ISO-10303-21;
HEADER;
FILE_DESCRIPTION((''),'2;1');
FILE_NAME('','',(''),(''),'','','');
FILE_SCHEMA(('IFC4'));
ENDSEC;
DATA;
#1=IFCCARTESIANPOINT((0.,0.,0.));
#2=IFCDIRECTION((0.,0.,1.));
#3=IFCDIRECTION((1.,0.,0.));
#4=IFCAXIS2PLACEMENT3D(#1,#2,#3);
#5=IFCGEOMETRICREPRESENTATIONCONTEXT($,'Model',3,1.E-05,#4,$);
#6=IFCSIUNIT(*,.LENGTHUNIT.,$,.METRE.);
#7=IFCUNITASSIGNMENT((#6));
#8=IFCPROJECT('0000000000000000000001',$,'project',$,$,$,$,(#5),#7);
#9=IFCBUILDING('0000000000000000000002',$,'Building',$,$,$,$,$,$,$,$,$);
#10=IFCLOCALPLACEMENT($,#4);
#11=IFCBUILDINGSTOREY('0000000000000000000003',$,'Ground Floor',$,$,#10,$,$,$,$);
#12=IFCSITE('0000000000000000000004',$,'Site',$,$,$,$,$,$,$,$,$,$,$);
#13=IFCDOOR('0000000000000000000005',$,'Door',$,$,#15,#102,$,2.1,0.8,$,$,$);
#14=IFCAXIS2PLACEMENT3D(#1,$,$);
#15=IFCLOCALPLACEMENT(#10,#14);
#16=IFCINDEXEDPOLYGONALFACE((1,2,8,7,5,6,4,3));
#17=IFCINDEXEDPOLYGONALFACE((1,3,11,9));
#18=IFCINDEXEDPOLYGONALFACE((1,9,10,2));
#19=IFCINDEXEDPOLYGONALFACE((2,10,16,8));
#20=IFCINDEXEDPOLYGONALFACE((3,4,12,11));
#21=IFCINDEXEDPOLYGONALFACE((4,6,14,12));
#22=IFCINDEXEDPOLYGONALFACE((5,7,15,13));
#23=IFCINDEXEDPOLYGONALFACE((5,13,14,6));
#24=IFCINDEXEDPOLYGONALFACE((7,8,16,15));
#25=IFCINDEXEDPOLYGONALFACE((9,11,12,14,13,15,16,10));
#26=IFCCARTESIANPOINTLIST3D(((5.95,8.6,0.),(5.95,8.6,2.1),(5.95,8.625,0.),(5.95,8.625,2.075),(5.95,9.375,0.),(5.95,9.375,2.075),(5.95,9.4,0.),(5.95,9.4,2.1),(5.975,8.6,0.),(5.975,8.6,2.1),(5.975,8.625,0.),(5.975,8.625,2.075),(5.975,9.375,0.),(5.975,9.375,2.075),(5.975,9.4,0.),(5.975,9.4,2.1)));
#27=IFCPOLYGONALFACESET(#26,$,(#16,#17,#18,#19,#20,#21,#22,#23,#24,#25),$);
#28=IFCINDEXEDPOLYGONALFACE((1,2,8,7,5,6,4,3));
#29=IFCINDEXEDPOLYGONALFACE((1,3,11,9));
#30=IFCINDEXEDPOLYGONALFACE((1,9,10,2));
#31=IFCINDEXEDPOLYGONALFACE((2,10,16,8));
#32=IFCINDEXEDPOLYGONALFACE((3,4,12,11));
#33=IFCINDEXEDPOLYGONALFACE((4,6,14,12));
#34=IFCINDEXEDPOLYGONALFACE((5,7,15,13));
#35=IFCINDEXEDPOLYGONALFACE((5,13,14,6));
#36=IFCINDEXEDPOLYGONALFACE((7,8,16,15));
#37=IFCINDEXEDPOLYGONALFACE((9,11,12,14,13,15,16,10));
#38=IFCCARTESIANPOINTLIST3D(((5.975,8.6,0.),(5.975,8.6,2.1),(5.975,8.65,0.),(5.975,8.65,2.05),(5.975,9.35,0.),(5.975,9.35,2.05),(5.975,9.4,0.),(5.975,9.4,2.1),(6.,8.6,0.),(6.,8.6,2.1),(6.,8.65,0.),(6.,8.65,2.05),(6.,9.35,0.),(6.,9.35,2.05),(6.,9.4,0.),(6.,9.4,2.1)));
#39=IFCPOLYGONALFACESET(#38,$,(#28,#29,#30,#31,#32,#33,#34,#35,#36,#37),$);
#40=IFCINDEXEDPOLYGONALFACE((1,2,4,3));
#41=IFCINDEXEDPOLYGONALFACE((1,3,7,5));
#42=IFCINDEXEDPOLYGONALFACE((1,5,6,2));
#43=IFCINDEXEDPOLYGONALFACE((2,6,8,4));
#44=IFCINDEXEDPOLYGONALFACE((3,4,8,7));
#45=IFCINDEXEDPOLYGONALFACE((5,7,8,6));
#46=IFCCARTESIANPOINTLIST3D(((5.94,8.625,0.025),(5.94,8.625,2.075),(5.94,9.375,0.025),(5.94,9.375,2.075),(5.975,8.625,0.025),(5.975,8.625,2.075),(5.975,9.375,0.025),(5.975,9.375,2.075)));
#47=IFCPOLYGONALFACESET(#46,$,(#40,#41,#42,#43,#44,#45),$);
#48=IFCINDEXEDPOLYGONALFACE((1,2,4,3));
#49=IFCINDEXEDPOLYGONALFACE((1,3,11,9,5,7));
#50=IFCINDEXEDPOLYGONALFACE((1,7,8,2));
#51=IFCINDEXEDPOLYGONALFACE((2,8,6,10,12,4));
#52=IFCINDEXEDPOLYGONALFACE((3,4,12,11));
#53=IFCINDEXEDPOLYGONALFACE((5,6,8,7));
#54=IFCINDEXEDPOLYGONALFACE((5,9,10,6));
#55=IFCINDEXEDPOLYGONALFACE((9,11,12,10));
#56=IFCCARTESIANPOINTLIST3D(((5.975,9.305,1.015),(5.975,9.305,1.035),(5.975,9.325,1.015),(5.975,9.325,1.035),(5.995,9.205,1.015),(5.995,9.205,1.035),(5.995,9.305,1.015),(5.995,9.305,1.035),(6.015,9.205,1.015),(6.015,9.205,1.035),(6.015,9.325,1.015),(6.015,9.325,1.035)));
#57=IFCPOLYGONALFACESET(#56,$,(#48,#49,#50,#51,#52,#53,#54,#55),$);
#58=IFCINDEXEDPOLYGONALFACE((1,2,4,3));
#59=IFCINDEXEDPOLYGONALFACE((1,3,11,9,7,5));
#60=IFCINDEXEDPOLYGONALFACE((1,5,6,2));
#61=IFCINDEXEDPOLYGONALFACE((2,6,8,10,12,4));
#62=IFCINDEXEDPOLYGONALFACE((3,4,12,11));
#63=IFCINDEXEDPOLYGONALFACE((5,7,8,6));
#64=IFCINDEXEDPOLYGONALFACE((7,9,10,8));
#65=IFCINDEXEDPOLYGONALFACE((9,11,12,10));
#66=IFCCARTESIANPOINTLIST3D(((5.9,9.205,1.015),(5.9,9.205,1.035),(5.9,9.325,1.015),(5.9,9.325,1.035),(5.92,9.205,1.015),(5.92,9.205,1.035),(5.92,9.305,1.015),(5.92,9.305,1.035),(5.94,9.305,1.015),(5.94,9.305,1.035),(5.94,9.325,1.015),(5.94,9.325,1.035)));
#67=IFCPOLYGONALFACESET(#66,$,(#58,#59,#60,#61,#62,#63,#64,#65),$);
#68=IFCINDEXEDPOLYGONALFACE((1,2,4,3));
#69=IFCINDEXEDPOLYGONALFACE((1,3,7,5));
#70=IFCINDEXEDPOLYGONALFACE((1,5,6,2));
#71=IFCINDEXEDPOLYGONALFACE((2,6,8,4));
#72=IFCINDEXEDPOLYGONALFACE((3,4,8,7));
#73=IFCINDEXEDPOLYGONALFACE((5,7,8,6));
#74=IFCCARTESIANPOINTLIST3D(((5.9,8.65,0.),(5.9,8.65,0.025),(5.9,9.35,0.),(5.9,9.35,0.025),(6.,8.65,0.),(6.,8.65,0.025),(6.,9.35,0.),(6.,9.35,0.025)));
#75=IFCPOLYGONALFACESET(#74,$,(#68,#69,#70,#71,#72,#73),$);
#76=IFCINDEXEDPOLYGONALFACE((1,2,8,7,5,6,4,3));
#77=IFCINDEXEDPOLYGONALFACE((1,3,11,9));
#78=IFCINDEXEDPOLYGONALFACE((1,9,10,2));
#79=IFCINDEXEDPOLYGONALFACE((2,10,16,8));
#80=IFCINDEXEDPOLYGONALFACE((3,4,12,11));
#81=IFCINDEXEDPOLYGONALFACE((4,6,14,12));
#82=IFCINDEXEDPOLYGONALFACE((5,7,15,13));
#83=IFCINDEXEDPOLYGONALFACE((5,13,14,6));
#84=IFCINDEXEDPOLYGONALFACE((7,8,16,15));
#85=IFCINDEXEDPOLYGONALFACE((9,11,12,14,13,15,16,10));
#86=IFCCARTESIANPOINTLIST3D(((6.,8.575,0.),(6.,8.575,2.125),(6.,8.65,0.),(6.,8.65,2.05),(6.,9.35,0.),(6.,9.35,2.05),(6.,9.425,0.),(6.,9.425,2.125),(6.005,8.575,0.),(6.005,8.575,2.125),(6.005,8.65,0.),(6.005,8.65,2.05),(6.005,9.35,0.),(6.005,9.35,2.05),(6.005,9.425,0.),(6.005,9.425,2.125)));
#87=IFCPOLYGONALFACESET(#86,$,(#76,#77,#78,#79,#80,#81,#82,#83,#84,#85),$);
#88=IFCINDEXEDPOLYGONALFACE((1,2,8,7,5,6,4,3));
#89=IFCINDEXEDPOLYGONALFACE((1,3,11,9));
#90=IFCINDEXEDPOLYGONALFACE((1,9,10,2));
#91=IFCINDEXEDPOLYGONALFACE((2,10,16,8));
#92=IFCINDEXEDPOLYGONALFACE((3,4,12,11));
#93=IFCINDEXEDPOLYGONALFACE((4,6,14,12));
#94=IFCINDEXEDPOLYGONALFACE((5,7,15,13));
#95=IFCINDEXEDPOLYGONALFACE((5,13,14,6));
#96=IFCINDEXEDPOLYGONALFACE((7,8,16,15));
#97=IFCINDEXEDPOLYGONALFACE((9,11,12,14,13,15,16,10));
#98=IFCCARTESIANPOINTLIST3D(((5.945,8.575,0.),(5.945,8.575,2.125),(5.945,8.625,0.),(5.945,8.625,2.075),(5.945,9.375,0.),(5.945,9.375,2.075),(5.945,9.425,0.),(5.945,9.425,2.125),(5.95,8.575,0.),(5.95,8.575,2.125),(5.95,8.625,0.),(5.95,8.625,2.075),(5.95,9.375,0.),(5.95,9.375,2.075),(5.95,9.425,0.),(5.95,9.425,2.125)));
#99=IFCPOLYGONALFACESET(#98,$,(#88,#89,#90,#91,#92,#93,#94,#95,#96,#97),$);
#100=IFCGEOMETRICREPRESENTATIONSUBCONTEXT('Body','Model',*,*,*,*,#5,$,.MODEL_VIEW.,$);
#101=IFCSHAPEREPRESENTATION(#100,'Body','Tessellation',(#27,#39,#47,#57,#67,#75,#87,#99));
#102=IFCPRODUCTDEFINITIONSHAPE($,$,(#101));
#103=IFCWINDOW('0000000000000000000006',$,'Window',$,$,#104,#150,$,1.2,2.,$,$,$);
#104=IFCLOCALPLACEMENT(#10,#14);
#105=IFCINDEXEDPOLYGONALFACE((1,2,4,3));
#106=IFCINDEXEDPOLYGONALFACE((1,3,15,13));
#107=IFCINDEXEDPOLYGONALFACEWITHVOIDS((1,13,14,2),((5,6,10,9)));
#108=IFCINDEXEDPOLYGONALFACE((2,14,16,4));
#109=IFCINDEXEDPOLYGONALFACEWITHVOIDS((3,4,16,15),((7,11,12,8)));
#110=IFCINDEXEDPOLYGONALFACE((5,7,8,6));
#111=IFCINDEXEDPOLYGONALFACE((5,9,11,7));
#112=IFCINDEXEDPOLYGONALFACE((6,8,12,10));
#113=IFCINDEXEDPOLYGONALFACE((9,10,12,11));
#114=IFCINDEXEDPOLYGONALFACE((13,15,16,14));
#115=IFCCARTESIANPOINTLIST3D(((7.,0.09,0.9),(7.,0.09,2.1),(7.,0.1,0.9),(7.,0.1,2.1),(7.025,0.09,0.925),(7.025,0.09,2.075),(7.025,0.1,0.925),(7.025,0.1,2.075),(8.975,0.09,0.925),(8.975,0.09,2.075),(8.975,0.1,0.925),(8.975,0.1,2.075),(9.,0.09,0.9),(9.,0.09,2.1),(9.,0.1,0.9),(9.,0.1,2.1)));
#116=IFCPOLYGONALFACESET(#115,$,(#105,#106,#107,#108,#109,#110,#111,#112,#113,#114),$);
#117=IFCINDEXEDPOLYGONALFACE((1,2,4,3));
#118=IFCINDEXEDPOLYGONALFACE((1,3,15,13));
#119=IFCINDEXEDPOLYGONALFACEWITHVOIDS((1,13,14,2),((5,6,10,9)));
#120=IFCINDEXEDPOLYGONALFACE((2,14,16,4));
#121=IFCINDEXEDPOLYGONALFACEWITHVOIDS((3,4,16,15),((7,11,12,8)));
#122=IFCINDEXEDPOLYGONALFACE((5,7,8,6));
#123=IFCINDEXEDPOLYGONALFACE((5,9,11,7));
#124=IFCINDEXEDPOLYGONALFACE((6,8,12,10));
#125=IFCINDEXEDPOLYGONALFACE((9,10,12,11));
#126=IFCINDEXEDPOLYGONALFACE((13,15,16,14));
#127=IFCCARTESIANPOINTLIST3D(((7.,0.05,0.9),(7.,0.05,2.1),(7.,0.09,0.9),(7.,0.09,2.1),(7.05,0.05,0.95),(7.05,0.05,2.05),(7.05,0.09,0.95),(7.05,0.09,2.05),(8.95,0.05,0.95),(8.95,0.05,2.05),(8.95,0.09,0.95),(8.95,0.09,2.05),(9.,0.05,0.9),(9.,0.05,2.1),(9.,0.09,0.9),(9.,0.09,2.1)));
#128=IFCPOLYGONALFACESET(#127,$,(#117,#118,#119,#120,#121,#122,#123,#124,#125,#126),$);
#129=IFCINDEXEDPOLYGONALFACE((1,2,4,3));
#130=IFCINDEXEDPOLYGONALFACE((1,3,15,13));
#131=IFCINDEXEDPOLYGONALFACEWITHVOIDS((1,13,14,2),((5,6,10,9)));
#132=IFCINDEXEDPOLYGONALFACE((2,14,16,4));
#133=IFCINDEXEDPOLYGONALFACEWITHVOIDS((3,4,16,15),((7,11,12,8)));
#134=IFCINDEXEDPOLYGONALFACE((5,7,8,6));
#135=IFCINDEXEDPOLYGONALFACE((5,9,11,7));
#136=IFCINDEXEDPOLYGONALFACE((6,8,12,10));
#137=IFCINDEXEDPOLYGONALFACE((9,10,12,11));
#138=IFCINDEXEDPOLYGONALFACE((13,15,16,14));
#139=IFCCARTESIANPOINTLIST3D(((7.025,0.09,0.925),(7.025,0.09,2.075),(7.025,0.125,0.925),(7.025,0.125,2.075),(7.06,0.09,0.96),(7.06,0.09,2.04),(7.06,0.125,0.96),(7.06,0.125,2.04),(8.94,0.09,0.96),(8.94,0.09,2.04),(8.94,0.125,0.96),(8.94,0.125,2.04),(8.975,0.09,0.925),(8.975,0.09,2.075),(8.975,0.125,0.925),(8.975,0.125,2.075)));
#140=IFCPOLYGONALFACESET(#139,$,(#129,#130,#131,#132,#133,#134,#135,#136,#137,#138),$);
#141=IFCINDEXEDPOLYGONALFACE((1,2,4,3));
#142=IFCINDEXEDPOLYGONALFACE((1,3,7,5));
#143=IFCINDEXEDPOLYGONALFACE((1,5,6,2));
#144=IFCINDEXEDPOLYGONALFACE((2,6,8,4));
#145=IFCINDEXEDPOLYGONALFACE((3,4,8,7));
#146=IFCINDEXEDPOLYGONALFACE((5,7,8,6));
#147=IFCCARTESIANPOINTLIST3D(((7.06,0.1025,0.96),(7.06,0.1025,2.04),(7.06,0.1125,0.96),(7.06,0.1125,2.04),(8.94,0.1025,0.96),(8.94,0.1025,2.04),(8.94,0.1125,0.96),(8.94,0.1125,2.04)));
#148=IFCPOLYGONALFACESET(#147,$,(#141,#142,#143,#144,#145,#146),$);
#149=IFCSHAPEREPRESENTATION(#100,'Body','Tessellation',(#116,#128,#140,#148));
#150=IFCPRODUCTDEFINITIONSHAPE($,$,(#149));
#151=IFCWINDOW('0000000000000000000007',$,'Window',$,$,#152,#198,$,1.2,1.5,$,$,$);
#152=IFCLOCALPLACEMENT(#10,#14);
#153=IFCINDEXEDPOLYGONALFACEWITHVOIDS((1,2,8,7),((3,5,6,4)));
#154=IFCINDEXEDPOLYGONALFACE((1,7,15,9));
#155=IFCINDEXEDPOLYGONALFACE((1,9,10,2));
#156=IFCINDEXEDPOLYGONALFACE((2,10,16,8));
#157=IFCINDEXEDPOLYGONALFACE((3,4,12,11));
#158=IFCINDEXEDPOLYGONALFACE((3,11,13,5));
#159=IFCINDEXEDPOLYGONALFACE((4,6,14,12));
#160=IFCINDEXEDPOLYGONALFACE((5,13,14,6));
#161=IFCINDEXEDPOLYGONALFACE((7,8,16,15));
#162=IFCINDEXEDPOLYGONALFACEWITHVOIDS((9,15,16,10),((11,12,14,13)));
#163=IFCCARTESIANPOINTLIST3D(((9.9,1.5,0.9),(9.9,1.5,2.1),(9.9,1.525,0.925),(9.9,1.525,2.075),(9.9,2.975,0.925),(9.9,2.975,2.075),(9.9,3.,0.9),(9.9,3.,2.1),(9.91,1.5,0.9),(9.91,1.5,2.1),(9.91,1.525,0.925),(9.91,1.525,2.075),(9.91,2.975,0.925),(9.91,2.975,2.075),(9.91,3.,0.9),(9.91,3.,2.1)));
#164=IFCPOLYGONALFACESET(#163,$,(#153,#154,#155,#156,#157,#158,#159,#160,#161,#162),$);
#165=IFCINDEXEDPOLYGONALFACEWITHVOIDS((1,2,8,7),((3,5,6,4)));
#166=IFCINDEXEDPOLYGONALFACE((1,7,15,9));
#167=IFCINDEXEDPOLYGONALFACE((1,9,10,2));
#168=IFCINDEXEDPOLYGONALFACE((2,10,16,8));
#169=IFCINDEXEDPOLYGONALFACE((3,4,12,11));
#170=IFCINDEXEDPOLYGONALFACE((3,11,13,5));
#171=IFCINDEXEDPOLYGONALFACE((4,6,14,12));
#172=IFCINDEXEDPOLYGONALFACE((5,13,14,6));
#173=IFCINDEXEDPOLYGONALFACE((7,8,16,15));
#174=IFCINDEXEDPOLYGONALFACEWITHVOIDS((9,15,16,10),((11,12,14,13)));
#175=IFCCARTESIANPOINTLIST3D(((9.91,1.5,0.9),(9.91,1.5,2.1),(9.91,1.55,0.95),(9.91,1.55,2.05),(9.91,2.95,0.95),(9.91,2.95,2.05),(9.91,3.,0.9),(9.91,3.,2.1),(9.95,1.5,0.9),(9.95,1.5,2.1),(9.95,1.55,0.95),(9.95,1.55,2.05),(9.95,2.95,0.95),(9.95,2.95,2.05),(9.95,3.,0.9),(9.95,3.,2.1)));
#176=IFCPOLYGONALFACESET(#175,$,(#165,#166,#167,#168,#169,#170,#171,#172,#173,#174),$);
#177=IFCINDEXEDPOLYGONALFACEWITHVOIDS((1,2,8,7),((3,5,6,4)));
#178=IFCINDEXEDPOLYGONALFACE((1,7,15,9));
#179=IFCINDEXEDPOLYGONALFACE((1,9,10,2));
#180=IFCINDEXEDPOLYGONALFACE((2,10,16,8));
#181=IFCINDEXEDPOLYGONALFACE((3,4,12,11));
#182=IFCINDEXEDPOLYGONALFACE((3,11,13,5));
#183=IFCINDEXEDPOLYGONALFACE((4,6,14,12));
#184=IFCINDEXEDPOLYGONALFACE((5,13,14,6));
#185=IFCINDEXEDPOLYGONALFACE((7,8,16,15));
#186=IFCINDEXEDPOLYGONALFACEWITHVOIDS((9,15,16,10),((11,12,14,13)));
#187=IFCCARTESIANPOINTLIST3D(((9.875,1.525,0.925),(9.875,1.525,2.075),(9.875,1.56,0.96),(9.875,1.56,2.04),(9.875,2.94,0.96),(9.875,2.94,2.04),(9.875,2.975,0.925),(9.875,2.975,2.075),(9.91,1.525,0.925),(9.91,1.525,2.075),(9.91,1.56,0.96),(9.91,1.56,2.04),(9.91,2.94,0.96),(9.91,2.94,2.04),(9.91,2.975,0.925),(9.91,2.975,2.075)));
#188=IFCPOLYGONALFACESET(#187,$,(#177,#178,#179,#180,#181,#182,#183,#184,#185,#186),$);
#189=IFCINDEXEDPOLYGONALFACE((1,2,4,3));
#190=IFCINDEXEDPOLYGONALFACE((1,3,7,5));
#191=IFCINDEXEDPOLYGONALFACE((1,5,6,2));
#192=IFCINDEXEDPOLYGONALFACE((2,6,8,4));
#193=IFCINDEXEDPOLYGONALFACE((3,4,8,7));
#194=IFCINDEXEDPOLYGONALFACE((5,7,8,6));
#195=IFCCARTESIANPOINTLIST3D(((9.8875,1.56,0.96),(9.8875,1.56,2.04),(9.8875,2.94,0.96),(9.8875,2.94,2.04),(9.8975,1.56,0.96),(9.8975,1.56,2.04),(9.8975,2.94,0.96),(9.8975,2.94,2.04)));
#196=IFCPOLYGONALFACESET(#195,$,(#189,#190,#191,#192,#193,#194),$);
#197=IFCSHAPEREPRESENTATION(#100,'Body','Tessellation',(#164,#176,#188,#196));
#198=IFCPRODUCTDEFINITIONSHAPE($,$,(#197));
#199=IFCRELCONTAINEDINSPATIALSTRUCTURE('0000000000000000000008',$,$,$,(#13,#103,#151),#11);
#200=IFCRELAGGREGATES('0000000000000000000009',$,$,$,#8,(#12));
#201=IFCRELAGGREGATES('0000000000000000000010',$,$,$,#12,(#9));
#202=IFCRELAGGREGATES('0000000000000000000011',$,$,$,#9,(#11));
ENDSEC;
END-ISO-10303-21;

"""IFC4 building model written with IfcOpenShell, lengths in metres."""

from ifc_helpers import new_model, si_unit, frame, origin_with_axes, place, context, subcontext, project, spatial, line, indexed_curve, outline, extrude, element, save


model = new_model("IFC4")

# Units and contexts
model_context = context("Model", 3, precision=1e-05, world=origin_with_axes())
body_context = subcontext(model_context, "Body", "Model", "MODEL_VIEW")
ifc_project = project(units=[si_unit("LENGTHUNIT", "METRE")], contexts=[model_context])

# Site, building, storey
site = spatial("IfcSite", under=ifc_project, Name="Site")
building = spatial("IfcBuilding", under=site, Name="Building")
storey_placement = place(None, origin_with_axes())
storey = spatial("IfcBuildingStorey", under=building, at=storey_placement, Name="Ground Floor")

# Door
door_1_placement = place(storey_placement, frame((6.0, 8.6, 0.0), z_axis=(0.0, 0.0, 1.0), x_axis=(0.0, 1.0, 0.0)))
element("IfcDoor", 1, at=door_1_placement, inside=storey, Name="Door", OverallHeight=2.1, OverallWidth=0.8, context=body_context, shape_type="SweptSolid", body=[
    extrude(outline(indexed_curve([(0.0, 0.0), (0.0, 2.1), (0.8, 2.1), (0.8, 0.0), (0.775, 0.0), (0.775, 2.075), (0.025, 2.075), (0.025, 0.0)], segments=[line(1, 2, 3, 4, 5, 6, 7, 8, 1)])), frame((0.0, 0.025, 0.0), z_axis=(0.0, -1.0, 0.0), x_axis=(1.0, 0.0, 0.0)), (0.0, 0.0, -1.0), 0.025),
    extrude(outline(indexed_curve([(0.0, 0.0), (0.0, 2.1), (0.8, 2.1), (0.8, 0.0), (0.75, 0.0), (0.75, 2.05), (0.05, 2.05), (0.05, 0.0)], segments=[line(1, 2, 3, 4, 5, 6, 7, 8, 1)])), frame((0.0, 0.0, 0.0), z_axis=(0.0, -1.0, 0.0), x_axis=(1.0, 0.0, 0.0)), (0.0, 0.0, -1.0), 0.025),
    extrude(outline(indexed_curve([(0.0, 0.0), (0.75, 0.0), (0.75, 0.035), (0.0, 0.035)], segments=[line(1, 2, 3, 4, 1)])), frame((0.025, 0.025, 0.025), z_axis=(0.0, 0.0, 1.0), x_axis=(1.0, 0.0, 0.0)), (0.0, 0.0, 1.0), 2.05),
    extrude(outline(indexed_curve([(0.0, 0.0), (0.0, -0.04), (-0.12, -0.04), (-0.12, -0.02), (-0.02, -0.02), (-0.02, 0.0)], segments=[line(1, 2, 3, 4, 5, 6, 1)])), frame((0.725, 0.025, 1.015), z_axis=(0.0, 0.0, 1.0), x_axis=(1.0, 0.0, 0.0)), (0.0, 0.0, 1.0), 0.02),
    extrude(outline(indexed_curve([(0.0, 0.0), (0.0, 0.04), (-0.12, 0.04), (-0.12, 0.02), (-0.02, 0.02), (-0.02, 0.0)], segments=[line(1, 2, 3, 4, 5, 6, 1)])), frame((0.725, 0.06, 1.015), z_axis=(0.0, 0.0, 1.0), x_axis=(1.0, 0.0, 0.0)), (0.0, 0.0, 1.0), 0.02),
    extrude(outline(indexed_curve([(0.0, 0.0), (0.7, 0.0), (0.7, 0.1), (0.0, 0.1)], segments=[line(1, 2, 3, 4, 1)])), frame((0.05, 0.0, 0.0), z_axis=(0.0, 0.0, 1.0), x_axis=(1.0, 0.0, 0.0)), (0.0, 0.0, 1.0), 0.025),
    extrude(outline(indexed_curve([(0.0, 0.0), (0.0, 2.125), (0.85, 2.125), (0.85, 0.0), (0.775, 0.0), (0.775, 2.05), (0.075, 2.05), (0.075, 0.0)], segments=[line(1, 2, 3, 4, 5, 6, 7, 8, 1)])), frame((-0.025, -0.005, 0.0), z_axis=(0.0, -1.0, 0.0), x_axis=(1.0, 0.0, 0.0)), (0.0, 0.0, -1.0), 0.005),
    extrude(outline(indexed_curve([(0.0, 0.0), (0.0, 2.125), (0.85, 2.125), (0.85, 0.0), (0.8, 0.0), (0.8, 2.075), (0.05, 2.075), (0.05, 0.0)], segments=[line(1, 2, 3, 4, 5, 6, 7, 8, 1)])), frame((-0.025, 0.05, 0.0), z_axis=(0.0, -1.0, 0.0), x_axis=(1.0, 0.0, 0.0)), (0.0, 0.0, -1.0), 0.005),
])

# Windows
window_1_placement = place(storey_placement, frame((7.0, 0.0, 0.9), z_axis=(0.0, 0.0, 1.0), x_axis=(1.0, 0.0, 0.0)))
element("IfcWindow", 2, at=window_1_placement, inside=storey, Name="Window", OverallHeight=1.2, OverallWidth=2.0, context=body_context, shape_type="SweptSolid", body=[
    extrude(outline(indexed_curve([(0.0, 0.0), (2.0, 0.0), (2.0, 1.2), (0.0, 1.2)], segments=[line(1, 2, 3, 4, 1)]), holes=[indexed_curve([(0.025, 0.025), (1.975, 0.025), (1.975, 1.175), (0.025, 1.175)], segments=[line(1, 2, 3, 4, 1)])]), frame((0.0, 0.09, 0.0), z_axis=(0.0, -1.0, 0.0), x_axis=(1.0, 0.0, 0.0)), (0.0, 0.0, -1.0), 0.01),
    extrude(outline(indexed_curve([(0.0, 0.0), (2.0, 0.0), (2.0, 1.2), (0.0, 1.2)], segments=[line(1, 2, 3, 4, 1)]), holes=[indexed_curve([(0.05, 0.05), (1.95, 0.05), (1.95, 1.15), (0.05, 1.15)], segments=[line(1, 2, 3, 4, 1)])]), frame((0.0, 0.05, 0.0), z_axis=(0.0, -1.0, 0.0), x_axis=(1.0, 0.0, 0.0)), (0.0, 0.0, -1.0), 0.04),
    extrude(outline(indexed_curve([(0.0, 0.0), (1.95, 0.0), (1.95, 1.15), (0.0, 1.15)], segments=[line(1, 2, 3, 4, 1)]), holes=[indexed_curve([(0.035, 0.035), (1.915, 0.035), (1.915, 1.115), (0.035, 1.115)], segments=[line(1, 2, 3, 4, 1)])]), frame((0.025, 0.09, 0.025), z_axis=(0.0, -1.0, 0.0), x_axis=(1.0, 0.0, 0.0)), (0.0, 0.0, -1.0), 0.035),
    extrude(outline(indexed_curve([(0.035, 0.035), (1.915, 0.035), (1.915, 1.115), (0.035, 1.115)], segments=[line(1, 2, 3, 4, 1)])), frame((0.025, 0.1025, 0.025), z_axis=(0.0, -1.0, 0.0), x_axis=(1.0, 0.0, 0.0)), (0.0, 0.0, -1.0), 0.01),
])
window_2_placement = place(storey_placement, frame((10.0, 1.5, 0.9), z_axis=(0.0, 0.0, 1.0), x_axis=(0.0, 1.0, 0.0)))
element("IfcWindow", 3, at=window_2_placement, inside=storey, Name="Window", OverallHeight=1.2, OverallWidth=1.5, context=body_context, shape_type="SweptSolid", body=[
    extrude(outline(indexed_curve([(0.0, 0.0), (1.5, 0.0), (1.5, 1.2), (0.0, 1.2)], segments=[line(1, 2, 3, 4, 1)]), holes=[indexed_curve([(0.025, 0.025), (1.475, 0.025), (1.475, 1.175), (0.025, 1.175)], segments=[line(1, 2, 3, 4, 1)])]), frame((0.0, 0.09, 0.0), z_axis=(0.0, -1.0, 0.0), x_axis=(1.0, 0.0, 0.0)), (0.0, 0.0, -1.0), 0.01),
    extrude(outline(indexed_curve([(0.0, 0.0), (1.5, 0.0), (1.5, 1.2), (0.0, 1.2)], segments=[line(1, 2, 3, 4, 1)]), holes=[indexed_curve([(0.05, 0.05), (1.45, 0.05), (1.45, 1.15), (0.05, 1.15)], segments=[line(1, 2, 3, 4, 1)])]), frame((0.0, 0.05, 0.0), z_axis=(0.0, -1.0, 0.0), x_axis=(1.0, 0.0, 0.0)), (0.0, 0.0, -1.0), 0.04),
    extrude(outline(indexed_curve([(0.0, 0.0), (1.45, 0.0), (1.45, 1.15), (0.0, 1.15)], segments=[line(1, 2, 3, 4, 1)]), holes=[indexed_curve([(0.035, 0.035), (1.415, 0.035), (1.415, 1.115), (0.035, 1.115)], segments=[line(1, 2, 3, 4, 1)])]), frame((0.025, 0.09, 0.025), z_axis=(0.0, -1.0, 0.0), x_axis=(1.0, 0.0, 0.0)), (0.0, 0.0, -1.0), 0.035),
    extrude(outline(indexed_curve([(0.035, 0.035), (1.415, 0.035), (1.415, 1.115), (0.035, 1.115)], segments=[line(1, 2, 3, 4, 1)])), frame((0.025, 0.1025, 0.025), z_axis=(0.0, -1.0, 0.0), x_axis=(1.0, 0.0, 0.0)), (0.0, 0.0, -1.0), 0.01),
])

save(model, "model.ifc")
